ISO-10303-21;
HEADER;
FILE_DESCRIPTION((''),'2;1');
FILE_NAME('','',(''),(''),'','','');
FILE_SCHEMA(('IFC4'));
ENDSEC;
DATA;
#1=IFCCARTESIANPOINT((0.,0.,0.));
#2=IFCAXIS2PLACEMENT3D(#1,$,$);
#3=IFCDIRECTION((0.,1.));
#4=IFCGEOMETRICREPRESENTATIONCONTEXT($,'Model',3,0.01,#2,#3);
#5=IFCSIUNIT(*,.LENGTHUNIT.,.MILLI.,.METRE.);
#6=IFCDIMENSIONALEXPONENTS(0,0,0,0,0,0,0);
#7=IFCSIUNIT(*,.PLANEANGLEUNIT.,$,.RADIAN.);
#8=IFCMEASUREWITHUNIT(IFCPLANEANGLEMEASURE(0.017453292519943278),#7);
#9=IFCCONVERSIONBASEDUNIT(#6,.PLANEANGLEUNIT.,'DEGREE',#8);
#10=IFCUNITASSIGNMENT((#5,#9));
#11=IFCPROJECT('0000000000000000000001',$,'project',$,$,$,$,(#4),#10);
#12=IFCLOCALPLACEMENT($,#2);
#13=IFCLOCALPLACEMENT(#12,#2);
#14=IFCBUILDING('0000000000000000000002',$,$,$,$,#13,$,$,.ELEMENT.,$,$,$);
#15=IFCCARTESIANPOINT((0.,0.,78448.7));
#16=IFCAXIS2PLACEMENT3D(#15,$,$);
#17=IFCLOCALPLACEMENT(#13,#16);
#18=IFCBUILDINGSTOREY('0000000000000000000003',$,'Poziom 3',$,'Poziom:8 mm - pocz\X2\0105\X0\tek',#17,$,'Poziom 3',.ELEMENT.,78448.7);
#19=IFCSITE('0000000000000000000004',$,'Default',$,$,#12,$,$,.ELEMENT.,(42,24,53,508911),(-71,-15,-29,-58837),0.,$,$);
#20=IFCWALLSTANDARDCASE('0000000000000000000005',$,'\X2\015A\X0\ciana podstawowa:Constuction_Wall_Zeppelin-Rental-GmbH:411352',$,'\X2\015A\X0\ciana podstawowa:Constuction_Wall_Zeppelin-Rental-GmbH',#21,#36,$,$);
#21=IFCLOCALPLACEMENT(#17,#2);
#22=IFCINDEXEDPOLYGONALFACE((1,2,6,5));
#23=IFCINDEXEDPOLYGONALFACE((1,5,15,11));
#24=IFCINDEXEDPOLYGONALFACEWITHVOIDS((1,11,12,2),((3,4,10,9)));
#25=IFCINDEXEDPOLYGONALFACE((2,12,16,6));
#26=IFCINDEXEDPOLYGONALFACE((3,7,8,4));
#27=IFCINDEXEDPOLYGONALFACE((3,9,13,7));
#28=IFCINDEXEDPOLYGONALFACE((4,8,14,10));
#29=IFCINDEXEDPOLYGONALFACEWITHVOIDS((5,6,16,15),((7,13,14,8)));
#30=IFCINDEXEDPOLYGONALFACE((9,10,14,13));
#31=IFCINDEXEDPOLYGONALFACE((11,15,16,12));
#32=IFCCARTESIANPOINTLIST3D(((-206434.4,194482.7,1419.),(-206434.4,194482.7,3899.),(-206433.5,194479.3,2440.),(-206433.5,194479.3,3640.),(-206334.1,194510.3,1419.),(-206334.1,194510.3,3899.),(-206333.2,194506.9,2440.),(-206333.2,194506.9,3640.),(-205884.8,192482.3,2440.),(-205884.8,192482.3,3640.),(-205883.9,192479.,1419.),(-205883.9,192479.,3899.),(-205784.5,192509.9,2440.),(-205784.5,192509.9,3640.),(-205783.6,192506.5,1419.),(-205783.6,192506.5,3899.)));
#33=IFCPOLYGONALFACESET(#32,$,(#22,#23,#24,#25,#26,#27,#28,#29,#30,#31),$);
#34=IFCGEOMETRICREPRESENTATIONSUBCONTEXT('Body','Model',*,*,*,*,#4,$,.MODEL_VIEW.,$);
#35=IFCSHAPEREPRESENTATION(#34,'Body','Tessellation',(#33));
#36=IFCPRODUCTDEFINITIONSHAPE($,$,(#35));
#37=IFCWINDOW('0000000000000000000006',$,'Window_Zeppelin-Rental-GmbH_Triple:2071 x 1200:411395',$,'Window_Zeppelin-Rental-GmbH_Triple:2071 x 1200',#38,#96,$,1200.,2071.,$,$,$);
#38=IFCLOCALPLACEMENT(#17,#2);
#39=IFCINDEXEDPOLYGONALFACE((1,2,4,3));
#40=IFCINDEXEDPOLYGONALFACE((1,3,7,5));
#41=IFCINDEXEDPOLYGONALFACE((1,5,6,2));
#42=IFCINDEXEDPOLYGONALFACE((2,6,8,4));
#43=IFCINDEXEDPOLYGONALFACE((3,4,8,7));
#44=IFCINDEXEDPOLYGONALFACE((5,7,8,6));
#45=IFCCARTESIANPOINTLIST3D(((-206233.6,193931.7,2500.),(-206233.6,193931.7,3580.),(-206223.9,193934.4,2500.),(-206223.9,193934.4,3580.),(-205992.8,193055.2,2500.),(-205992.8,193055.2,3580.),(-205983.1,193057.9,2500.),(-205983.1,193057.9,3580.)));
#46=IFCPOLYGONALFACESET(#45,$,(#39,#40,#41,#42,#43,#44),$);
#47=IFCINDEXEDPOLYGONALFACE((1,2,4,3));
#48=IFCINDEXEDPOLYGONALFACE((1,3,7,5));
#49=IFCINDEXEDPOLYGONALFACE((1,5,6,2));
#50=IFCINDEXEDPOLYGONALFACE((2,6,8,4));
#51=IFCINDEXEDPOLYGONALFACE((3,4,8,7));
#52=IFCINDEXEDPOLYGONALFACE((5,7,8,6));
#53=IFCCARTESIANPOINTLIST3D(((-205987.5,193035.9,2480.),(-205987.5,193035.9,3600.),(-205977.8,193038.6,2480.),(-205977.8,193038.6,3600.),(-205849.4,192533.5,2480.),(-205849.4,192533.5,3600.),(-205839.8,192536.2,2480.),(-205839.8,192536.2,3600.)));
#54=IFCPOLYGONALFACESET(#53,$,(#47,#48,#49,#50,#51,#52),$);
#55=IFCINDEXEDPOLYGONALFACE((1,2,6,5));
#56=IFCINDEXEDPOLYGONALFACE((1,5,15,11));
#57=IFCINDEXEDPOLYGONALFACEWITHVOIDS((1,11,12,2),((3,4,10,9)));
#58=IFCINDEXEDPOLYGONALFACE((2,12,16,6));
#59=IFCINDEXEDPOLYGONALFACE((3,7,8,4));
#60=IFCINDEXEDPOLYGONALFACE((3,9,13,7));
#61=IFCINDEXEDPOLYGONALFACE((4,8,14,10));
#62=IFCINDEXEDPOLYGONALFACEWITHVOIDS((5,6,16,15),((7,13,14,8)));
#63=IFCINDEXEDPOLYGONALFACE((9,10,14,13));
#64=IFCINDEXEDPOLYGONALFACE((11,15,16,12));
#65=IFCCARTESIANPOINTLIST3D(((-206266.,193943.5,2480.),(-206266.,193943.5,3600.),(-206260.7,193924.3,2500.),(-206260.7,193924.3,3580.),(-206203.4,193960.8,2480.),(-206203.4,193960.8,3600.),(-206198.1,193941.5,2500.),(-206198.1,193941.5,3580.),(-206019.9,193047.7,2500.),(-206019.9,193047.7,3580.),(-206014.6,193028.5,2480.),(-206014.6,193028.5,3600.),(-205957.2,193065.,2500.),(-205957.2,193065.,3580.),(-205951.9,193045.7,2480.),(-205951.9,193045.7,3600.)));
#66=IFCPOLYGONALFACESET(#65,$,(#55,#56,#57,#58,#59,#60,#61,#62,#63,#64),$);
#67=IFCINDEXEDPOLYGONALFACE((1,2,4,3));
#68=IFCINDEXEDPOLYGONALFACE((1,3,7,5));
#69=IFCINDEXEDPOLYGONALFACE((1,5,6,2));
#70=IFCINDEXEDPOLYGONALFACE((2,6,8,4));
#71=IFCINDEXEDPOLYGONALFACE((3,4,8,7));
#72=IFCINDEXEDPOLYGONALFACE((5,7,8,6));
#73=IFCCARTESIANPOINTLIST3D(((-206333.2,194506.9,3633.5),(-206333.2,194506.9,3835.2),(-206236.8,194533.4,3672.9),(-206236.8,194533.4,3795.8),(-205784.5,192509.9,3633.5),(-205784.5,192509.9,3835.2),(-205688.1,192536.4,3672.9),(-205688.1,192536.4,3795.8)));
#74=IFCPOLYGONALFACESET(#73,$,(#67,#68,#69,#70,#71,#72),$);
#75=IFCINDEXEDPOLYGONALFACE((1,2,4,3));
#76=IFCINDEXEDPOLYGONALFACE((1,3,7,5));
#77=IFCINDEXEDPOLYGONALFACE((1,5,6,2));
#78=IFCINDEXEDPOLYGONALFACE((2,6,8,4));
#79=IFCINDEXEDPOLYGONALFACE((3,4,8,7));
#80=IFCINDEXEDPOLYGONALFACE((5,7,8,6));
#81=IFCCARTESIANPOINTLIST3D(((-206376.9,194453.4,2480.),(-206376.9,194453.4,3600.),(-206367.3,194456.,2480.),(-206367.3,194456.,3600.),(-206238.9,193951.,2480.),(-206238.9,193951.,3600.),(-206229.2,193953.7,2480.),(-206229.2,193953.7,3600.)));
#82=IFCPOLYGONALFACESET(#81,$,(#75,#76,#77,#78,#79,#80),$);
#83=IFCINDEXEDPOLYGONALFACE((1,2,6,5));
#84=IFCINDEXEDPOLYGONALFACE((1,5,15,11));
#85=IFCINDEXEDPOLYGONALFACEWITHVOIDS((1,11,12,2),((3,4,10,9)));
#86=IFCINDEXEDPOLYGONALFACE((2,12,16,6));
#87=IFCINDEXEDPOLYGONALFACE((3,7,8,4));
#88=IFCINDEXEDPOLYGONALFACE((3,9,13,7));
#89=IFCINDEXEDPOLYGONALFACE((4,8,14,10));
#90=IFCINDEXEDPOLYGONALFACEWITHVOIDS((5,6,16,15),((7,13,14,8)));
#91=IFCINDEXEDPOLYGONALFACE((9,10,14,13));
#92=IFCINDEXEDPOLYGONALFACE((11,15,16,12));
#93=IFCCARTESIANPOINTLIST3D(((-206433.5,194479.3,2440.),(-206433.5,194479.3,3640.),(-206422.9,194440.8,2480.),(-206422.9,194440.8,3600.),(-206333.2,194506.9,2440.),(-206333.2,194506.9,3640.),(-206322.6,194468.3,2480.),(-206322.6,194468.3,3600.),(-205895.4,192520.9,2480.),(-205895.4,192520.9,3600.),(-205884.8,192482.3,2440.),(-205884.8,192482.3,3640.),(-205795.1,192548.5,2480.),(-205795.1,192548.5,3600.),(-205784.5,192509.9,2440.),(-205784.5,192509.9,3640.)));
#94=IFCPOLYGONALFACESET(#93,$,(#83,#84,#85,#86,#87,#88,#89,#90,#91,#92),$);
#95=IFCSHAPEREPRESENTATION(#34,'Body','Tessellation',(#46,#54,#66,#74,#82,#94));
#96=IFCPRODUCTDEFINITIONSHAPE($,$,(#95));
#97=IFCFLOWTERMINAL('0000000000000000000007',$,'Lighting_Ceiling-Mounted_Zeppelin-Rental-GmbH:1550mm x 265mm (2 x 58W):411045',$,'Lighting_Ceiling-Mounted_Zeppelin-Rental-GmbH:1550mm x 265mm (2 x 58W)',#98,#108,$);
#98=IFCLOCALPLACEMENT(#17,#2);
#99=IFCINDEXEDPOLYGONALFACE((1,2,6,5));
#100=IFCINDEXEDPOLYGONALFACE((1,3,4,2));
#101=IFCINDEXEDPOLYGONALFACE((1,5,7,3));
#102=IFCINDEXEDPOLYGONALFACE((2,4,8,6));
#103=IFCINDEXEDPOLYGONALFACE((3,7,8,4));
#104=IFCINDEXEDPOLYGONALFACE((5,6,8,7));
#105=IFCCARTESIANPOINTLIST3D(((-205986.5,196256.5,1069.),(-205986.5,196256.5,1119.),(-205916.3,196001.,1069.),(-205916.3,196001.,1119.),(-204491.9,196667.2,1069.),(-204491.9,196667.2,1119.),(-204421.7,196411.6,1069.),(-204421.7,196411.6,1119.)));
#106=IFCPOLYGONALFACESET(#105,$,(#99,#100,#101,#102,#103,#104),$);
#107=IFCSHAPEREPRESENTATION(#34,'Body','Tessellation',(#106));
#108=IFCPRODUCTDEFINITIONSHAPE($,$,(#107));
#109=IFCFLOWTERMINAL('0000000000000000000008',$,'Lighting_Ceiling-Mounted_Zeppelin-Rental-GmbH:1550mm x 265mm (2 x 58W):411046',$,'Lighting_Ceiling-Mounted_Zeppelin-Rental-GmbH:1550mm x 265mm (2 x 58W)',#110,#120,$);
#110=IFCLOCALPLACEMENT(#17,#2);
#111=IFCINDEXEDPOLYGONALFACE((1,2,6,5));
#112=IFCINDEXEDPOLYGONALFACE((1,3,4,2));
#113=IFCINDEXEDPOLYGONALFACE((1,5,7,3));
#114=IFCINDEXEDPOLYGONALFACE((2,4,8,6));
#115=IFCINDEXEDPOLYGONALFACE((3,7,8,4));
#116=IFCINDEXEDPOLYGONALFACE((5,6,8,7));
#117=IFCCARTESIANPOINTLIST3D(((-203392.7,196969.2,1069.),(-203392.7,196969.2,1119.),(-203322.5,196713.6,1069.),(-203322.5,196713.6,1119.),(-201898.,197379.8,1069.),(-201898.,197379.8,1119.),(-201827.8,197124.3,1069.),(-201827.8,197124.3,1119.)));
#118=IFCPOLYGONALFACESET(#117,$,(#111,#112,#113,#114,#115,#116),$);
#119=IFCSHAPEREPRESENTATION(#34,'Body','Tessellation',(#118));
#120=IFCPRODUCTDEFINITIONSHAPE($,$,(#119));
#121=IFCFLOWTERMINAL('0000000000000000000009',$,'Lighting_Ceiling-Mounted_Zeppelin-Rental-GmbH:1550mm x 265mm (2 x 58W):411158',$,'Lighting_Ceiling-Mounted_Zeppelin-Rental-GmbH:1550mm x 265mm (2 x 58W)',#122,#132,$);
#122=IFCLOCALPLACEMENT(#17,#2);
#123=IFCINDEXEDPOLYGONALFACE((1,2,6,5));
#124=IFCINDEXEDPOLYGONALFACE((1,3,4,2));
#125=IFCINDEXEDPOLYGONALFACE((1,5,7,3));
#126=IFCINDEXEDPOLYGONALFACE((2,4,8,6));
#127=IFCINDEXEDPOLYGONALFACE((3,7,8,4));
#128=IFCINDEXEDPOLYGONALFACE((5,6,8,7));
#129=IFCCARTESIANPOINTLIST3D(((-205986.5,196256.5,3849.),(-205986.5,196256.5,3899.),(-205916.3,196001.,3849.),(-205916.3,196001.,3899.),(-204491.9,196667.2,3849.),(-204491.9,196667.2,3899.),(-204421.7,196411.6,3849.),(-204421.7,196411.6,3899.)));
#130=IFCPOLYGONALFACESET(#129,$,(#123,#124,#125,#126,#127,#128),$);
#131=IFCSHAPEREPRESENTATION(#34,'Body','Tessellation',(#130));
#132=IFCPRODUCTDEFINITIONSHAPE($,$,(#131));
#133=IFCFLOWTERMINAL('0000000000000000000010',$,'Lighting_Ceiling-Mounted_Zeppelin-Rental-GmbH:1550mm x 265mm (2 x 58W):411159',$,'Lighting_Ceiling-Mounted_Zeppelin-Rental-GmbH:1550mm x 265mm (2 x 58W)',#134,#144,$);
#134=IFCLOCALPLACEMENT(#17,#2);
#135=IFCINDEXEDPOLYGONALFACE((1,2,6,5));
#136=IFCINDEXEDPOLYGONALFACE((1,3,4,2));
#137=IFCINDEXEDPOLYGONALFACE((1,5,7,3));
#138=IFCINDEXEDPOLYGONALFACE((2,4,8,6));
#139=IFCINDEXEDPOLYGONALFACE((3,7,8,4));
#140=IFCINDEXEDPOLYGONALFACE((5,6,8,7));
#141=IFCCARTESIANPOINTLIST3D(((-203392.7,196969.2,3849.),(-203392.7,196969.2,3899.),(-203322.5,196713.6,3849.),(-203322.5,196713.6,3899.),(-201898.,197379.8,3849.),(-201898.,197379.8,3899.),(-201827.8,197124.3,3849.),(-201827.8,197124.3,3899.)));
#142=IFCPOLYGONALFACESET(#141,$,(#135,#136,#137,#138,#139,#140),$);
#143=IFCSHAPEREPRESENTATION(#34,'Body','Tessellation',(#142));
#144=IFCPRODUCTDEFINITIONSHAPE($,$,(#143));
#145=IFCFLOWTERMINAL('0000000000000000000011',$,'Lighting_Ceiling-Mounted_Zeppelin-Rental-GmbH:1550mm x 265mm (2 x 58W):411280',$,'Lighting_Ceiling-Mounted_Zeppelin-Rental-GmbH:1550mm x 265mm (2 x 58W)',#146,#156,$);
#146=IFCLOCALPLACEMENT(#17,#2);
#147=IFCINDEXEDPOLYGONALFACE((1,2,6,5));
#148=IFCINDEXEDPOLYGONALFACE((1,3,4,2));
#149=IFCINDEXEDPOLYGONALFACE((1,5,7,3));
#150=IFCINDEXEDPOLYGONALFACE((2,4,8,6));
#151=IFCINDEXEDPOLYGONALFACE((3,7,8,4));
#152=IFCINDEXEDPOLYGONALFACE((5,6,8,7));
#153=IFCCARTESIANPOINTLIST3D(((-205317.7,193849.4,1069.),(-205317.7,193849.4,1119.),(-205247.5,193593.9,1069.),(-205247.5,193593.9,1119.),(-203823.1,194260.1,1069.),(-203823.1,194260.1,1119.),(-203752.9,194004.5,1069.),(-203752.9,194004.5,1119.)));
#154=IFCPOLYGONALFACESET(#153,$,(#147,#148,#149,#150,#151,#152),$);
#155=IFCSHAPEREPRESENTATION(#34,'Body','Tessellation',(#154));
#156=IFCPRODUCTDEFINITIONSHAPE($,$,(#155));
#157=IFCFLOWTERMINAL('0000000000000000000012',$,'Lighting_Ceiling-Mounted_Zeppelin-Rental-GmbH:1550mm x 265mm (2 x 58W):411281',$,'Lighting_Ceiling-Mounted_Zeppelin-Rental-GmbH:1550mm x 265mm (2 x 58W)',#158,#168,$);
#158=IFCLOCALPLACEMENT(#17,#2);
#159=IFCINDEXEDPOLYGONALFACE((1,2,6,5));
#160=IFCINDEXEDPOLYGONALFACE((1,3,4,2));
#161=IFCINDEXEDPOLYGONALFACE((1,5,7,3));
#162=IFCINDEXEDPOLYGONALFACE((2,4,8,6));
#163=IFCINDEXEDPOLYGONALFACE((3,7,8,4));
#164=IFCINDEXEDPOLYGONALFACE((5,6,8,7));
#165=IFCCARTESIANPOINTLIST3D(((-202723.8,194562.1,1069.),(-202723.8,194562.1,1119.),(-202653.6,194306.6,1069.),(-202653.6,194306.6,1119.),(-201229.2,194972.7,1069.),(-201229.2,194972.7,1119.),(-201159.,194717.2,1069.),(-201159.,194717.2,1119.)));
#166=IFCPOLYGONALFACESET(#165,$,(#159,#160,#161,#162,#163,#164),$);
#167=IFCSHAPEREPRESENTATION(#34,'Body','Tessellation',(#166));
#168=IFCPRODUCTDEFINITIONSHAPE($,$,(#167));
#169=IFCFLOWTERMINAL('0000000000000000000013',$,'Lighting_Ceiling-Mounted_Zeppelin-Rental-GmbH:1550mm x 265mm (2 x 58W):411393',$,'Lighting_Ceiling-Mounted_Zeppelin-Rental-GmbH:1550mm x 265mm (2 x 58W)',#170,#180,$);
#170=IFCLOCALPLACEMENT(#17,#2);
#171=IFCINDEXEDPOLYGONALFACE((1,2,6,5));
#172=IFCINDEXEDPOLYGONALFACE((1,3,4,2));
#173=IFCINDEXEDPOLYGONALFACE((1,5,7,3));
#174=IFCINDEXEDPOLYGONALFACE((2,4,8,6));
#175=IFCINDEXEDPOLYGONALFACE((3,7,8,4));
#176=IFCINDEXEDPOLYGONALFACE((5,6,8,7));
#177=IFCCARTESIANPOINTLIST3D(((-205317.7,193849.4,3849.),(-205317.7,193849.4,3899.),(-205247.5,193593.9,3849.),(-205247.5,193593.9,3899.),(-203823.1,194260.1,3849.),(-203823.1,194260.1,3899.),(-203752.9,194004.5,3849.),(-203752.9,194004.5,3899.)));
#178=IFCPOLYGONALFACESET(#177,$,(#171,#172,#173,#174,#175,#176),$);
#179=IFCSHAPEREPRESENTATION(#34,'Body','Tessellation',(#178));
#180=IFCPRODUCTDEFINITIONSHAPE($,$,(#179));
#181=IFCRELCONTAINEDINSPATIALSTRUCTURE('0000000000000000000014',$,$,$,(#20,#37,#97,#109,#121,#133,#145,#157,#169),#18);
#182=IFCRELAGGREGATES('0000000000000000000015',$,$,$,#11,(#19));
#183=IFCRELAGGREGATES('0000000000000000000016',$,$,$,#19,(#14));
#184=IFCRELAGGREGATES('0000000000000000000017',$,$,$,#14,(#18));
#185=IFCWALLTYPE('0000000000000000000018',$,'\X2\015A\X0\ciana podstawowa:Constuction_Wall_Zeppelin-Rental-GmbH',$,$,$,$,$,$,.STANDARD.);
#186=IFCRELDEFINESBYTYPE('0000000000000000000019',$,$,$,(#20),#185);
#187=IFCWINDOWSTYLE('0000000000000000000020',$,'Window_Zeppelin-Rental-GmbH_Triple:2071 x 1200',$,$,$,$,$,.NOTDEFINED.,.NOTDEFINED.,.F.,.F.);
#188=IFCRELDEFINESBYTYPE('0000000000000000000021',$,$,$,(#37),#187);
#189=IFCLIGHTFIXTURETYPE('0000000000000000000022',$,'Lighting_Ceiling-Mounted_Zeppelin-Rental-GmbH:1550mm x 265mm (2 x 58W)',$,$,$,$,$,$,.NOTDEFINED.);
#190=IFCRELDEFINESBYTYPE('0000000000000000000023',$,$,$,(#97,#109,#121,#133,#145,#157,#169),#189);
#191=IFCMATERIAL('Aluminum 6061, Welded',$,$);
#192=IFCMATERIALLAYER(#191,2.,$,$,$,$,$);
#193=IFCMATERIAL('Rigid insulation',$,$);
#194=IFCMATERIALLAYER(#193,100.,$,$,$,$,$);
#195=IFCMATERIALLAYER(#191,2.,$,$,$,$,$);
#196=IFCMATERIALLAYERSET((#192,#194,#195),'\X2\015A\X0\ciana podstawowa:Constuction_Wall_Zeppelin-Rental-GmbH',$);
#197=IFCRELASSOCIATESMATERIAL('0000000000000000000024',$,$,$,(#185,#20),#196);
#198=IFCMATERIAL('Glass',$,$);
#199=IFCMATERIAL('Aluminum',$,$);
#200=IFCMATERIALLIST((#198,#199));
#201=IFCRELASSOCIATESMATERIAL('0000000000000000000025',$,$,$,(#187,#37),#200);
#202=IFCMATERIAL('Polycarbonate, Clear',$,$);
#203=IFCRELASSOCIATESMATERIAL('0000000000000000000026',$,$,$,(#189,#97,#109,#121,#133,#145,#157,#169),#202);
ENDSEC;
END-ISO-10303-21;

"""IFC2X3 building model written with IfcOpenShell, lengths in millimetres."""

from ifc_helpers import new_model, entity, si_unit, converted_unit, direction, frame, frame_2d, origin, origin_2d_with_axis, place, context, subcontext, project, spatial, polyline, rectangle, outline, extrude, source, transform, mapped, material, material_list, layer, layer_set, layer_usage, type_object, type_shapes, element, fill, save


model = new_model("IFC2X3")

# Units and contexts
model_context = context("Model", 3, precision=0.01, world=origin(), true_north=direction((0.0, 1.0)))
body_context = subcontext(model_context, "Body", "Model", "MODEL_VIEW")
ifc_project = project(units=[si_unit("LENGTHUNIT", "METRE", prefix="MILLI"), converted_unit("PLANEANGLEUNIT", "DEGREE", entity("IfcPlaneAngleMeasure", 0.017453292519943278), si_unit("PLANEANGLEUNIT", "RADIAN"), dimensions=[0, 0, 0, 0, 0, 0, 0])], contexts=[model_context])

# Site, building, storey
site_placement = place(None, origin())
site = spatial("IfcSite", under=ifc_project, at=site_placement, Name="Default", CompositionType="ELEMENT", RefLatitude=(42, 24, 53, 508911), RefLongitude=(-71, -15, -29, -58837), RefElevation=0.0)
building_placement = place(site_placement, origin())
building = spatial("IfcBuilding", under=site, at=building_placement, CompositionType="ELEMENT")
storey_placement = place(building_placement, frame((0.0, 0.0, 78448.7)))
storey = spatial("IfcBuildingStorey", under=building, at=storey_placement, Name="Poziom 3", ObjectType="Poziom:8 mm - początek", LongName="Poziom 3", CompositionType="ELEMENT", Elevation=78448.7)

# Shared definitions
ifc_material_1 = material(Name="Aluminum 6061, Welded")
ifc_layer_1 = layer(ifc_material_1, 2.0)
ifc_material_2 = material(Name="Rigid insulation")
ifc_layer_2 = layer(ifc_material_2, 100.0)
ifc_layer_3 = layer(ifc_material_1, 2.0)
ifc_layer_set_1 = layer_set([ifc_layer_1, ifc_layer_2, ifc_layer_3], Name="Ściana podstawowa:Constuction_Wall_Zeppelin-Rental-GmbH")
wall_type_1 = type_object("IfcWallType", Name="Ściana podstawowa:Constuction_Wall_Zeppelin-Rental-GmbH", PredefinedType="STANDARD", material=ifc_layer_set_1)

# Shared definitions
ifc_material_3 = material(Name="Glass")
ifc_material_4 = material(Name="Aluminum")
ifc_material_list = material_list([ifc_material_3, ifc_material_4])
window_style = type_object("IfcWindowStyle", Name="Window_Zeppelin-Rental-GmbH_Triple:2071 x 1200", ConstructionType="NOTDEFINED", OperationType="NOTDEFINED", ParameterTakesPrecedence=False, Sizeable=False, material=ifc_material_list)
shared_shape_1 = source(origin(), body_context, "Body", "SweptSolid", [
    extrude(rectangle(XDim=10.0, YDim=909.0, at=origin_2d_with_axis()), frame((1035.5, 52.7, 60.0), z_axis=(0.0, 0.0, 1.0), x_axis=(0.0, -1.0, 0.0)), (0.0, 0.0, 1.0), 1080.0),
    extrude(rectangle(XDim=521.0, YDim=10.0, at=frame_2d((0.0, 0.0), x_axis=(1.0, 0.0))), frame((300.5, 52.7, 40.0), z_axis=(0.0, 0.0, 1.0), x_axis=(-1.0, 0.0, 0.0)), (0.0, 0.0, 1.0), 1120.0),
    extrude(outline(polyline([(-474.5, -560.0), (474.5, -560.0), (474.5, 560.0), (-474.5, 560.0), (-474.5, -560.0)]), holes=[polyline([(-454.5, 540.0), (454.5, 540.0), (454.5, -540.0), (-454.5, -540.0), (-454.5, 540.0)])]), frame((1035.5, 85.8, 600.0), z_axis=(0.0, -1.0, 0.0), x_axis=(1.0, 0.0, 0.0)), (0.0, 0.0, 1.0), 65.0),
    extrude(outline(polyline([(-24.0, -75.5), (83.5, -75.5), (9.6, 112.1), (-69.0, 38.9), (-24.0, -75.5)])), frame((2071.0, -48.7, 1294.4), z_axis=(-1.0, 0.0, 0.0), x_axis=(0.0, 0.930458, 0.366398)), (0.0, 0.0, 1.0), 2071.0),
    extrude(rectangle(XDim=10.0, YDim=521.0, at=frame_2d((0.0, 0.0), x_axis=(1.0, 0.0))), frame((1770.5, 52.7, 40.0), z_axis=(0.0, 0.0, 1.0), x_axis=(0.0, -1.0, 0.0)), (0.0, 0.0, 1.0), 1120.0),
    extrude(outline(polyline([(-1035.5, -600.0), (1035.5, -600.0), (1035.5, 600.0), (-1035.5, 600.0), (-1035.5, -600.0)]), holes=[polyline([(-995.5, 560.0), (995.5, 560.0), (995.5, -560.0), (-995.5, -560.0), (-995.5, 560.0)])]), frame((1035.5, 105.3, 600.0), z_axis=(0.0, -1.0, 0.0), x_axis=(1.0, 0.0, 0.0)), (0.0, 0.0, 1.0), 104.0),
])
type_shapes(window_style, [shared_shape_1])

# Wall, opening, window
ifc_layer_usage_1 = layer_usage(ifc_layer_set_1, "AXIS2", "NEGATIVE", 52.0)
wall_1_placement = place(storey_placement, frame((-205833.7, 192492.7, 1419.0), z_axis=(0.0, 0.0, 1.0), x_axis=(-0.264931, 0.964267, 0.0)))
wall_1 = element("IfcWallStandardCase", 1, at=wall_1_placement, inside=storey, type_object=wall_type_1, material=ifc_layer_usage_1, Name="Ściana podstawowa:Constuction_Wall_Zeppelin-Rental-GmbH:411352", ObjectType="Ściana podstawowa:Constuction_Wall_Zeppelin-Rental-GmbH", context=body_context, shape_type="SweptSolid", body=[
    extrude(rectangle(XDim=2078.0, YDim=104.0, at=frame_2d((1039.0, 0.0), x_axis=(-1.0, 0.0))), origin(), (0.0, 0.0, 1.0), 2480.0),
])
opening_1_placement = place(wall_1_placement, frame((3.5, -52.0, 1021.0)))
opening_1 = element("IfcOpeningElement", 2, at=opening_1_placement, cuts=wall_1, ObjectType="Opening", context=body_context, shape_type="SweptSolid", body=[
    extrude(rectangle(XDim=1200.0, YDim=2071.0, at=frame_2d((600.0, 1035.5), x_axis=(1.0, 0.0))), frame((0.0, 0.0, 0.0), z_axis=(0.0, 1.0, 0.0), x_axis=(0.0, 0.0, 1.0)), (0.0, 0.0, 1.0), 104.0),
])
window_1_placement = place(opening_1_placement, frame((0.0, -1.3, 0.0)))
window_1 = element("IfcWindow", 3, at=window_1_placement, inside=storey, type_object=window_style, material=ifc_material_list, Name="Window_Zeppelin-Rental-GmbH_Triple:2071 x 1200:411395", ObjectType="Window_Zeppelin-Rental-GmbH_Triple:2071 x 1200", OverallHeight=1200.0, OverallWidth=2071.0, context=body_context, shape_type="MappedRepresentation", body=[
    mapped(shared_shape_1, transform((0.0, 0.0, 0.0), scale=1.0)),
])
fill(opening_1, window_1)

# Flow terminals
ifc_material_5 = material(Name="Polycarbonate, Clear")
light_fixture_type = type_object("IfcLightFixtureType", Name="Lighting_Ceiling-Mounted_Zeppelin-Rental-GmbH:1550mm x 265mm (2 x 58W)", PredefinedType="NOTDEFINED", material=ifc_material_5)
shared_shape_2 = source(origin(), body_context, "Body", "SweptSolid", [
    extrude(rectangle(XDim=1550.0, YDim=265.0, at=origin_2d_with_axis()), frame((0.0, 0.0, 0.0), z_axis=(0.0, 0.0, 1.0), x_axis=(-1.0, 0.0, 0.0)), (0.0, 0.0, 1.0), 50.0),
])
type_shapes(light_fixture_type, [shared_shape_2])
for number, where, z_axis, x_axis, name in (
    (4, (-205204.1, 196334.1, 1119.0), (0.0, 0.0, -1.0), (-0.964267, -0.264931, 0.0), "Lighting_Ceiling-Mounted_Zeppelin-Rental-GmbH:1550mm x 265mm (2 x 58W):411045"),
    (5, (-202610.2, 197046.7, 1119.0), (0.0, 0.0, -1.0), (-0.964267, -0.264931, 0.0), "Lighting_Ceiling-Mounted_Zeppelin-Rental-GmbH:1550mm x 265mm (2 x 58W):411046"),
    (6, (-205204.1, 196334.1, 3899.0), (0.0, 0.0, -1.0), (-0.964267, -0.264931, 0.0), "Lighting_Ceiling-Mounted_Zeppelin-Rental-GmbH:1550mm x 265mm (2 x 58W):411158"),
    (7, (-202610.2, 197046.7, 3899.0), (0.0, 0.0, -1.0), (-0.964267, -0.264931, 0.0), "Lighting_Ceiling-Mounted_Zeppelin-Rental-GmbH:1550mm x 265mm (2 x 58W):411159"),
    (8, (-204535.3, 193927.0, 1119.0), (0.0, 0.0, -1.0), (-0.964267, -0.264931, 0.0), "Lighting_Ceiling-Mounted_Zeppelin-Rental-GmbH:1550mm x 265mm (2 x 58W):411280"),
    (9, (-201941.4, 194639.6, 1119.0), (0.0, 0.0, -1.0), (-0.964267, -0.264931, 0.0), "Lighting_Ceiling-Mounted_Zeppelin-Rental-GmbH:1550mm x 265mm (2 x 58W):411281"),
    (10, (-204535.3, 193927.0, 3899.0), (0.0, 0.0, -1.0), (-0.964267, -0.264931, 0.0), "Lighting_Ceiling-Mounted_Zeppelin-Rental-GmbH:1550mm x 265mm (2 x 58W):411393"),
):
    element("IfcFlowTerminal", number, at=place(storey_placement, frame(where, z_axis=z_axis, x_axis=x_axis)), inside=storey, type_object=light_fixture_type, material=ifc_material_5, Name=name, ObjectType="Lighting_Ceiling-Mounted_Zeppelin-Rental-GmbH:1550mm x 265mm (2 x 58W)", context=body_context, shape_type="MappedRepresentation", body=[
        mapped(shared_shape_2, transform((0.0, 0.0, 0.0), scale=1.0)),
    ])

save(model, "model.ifc")
